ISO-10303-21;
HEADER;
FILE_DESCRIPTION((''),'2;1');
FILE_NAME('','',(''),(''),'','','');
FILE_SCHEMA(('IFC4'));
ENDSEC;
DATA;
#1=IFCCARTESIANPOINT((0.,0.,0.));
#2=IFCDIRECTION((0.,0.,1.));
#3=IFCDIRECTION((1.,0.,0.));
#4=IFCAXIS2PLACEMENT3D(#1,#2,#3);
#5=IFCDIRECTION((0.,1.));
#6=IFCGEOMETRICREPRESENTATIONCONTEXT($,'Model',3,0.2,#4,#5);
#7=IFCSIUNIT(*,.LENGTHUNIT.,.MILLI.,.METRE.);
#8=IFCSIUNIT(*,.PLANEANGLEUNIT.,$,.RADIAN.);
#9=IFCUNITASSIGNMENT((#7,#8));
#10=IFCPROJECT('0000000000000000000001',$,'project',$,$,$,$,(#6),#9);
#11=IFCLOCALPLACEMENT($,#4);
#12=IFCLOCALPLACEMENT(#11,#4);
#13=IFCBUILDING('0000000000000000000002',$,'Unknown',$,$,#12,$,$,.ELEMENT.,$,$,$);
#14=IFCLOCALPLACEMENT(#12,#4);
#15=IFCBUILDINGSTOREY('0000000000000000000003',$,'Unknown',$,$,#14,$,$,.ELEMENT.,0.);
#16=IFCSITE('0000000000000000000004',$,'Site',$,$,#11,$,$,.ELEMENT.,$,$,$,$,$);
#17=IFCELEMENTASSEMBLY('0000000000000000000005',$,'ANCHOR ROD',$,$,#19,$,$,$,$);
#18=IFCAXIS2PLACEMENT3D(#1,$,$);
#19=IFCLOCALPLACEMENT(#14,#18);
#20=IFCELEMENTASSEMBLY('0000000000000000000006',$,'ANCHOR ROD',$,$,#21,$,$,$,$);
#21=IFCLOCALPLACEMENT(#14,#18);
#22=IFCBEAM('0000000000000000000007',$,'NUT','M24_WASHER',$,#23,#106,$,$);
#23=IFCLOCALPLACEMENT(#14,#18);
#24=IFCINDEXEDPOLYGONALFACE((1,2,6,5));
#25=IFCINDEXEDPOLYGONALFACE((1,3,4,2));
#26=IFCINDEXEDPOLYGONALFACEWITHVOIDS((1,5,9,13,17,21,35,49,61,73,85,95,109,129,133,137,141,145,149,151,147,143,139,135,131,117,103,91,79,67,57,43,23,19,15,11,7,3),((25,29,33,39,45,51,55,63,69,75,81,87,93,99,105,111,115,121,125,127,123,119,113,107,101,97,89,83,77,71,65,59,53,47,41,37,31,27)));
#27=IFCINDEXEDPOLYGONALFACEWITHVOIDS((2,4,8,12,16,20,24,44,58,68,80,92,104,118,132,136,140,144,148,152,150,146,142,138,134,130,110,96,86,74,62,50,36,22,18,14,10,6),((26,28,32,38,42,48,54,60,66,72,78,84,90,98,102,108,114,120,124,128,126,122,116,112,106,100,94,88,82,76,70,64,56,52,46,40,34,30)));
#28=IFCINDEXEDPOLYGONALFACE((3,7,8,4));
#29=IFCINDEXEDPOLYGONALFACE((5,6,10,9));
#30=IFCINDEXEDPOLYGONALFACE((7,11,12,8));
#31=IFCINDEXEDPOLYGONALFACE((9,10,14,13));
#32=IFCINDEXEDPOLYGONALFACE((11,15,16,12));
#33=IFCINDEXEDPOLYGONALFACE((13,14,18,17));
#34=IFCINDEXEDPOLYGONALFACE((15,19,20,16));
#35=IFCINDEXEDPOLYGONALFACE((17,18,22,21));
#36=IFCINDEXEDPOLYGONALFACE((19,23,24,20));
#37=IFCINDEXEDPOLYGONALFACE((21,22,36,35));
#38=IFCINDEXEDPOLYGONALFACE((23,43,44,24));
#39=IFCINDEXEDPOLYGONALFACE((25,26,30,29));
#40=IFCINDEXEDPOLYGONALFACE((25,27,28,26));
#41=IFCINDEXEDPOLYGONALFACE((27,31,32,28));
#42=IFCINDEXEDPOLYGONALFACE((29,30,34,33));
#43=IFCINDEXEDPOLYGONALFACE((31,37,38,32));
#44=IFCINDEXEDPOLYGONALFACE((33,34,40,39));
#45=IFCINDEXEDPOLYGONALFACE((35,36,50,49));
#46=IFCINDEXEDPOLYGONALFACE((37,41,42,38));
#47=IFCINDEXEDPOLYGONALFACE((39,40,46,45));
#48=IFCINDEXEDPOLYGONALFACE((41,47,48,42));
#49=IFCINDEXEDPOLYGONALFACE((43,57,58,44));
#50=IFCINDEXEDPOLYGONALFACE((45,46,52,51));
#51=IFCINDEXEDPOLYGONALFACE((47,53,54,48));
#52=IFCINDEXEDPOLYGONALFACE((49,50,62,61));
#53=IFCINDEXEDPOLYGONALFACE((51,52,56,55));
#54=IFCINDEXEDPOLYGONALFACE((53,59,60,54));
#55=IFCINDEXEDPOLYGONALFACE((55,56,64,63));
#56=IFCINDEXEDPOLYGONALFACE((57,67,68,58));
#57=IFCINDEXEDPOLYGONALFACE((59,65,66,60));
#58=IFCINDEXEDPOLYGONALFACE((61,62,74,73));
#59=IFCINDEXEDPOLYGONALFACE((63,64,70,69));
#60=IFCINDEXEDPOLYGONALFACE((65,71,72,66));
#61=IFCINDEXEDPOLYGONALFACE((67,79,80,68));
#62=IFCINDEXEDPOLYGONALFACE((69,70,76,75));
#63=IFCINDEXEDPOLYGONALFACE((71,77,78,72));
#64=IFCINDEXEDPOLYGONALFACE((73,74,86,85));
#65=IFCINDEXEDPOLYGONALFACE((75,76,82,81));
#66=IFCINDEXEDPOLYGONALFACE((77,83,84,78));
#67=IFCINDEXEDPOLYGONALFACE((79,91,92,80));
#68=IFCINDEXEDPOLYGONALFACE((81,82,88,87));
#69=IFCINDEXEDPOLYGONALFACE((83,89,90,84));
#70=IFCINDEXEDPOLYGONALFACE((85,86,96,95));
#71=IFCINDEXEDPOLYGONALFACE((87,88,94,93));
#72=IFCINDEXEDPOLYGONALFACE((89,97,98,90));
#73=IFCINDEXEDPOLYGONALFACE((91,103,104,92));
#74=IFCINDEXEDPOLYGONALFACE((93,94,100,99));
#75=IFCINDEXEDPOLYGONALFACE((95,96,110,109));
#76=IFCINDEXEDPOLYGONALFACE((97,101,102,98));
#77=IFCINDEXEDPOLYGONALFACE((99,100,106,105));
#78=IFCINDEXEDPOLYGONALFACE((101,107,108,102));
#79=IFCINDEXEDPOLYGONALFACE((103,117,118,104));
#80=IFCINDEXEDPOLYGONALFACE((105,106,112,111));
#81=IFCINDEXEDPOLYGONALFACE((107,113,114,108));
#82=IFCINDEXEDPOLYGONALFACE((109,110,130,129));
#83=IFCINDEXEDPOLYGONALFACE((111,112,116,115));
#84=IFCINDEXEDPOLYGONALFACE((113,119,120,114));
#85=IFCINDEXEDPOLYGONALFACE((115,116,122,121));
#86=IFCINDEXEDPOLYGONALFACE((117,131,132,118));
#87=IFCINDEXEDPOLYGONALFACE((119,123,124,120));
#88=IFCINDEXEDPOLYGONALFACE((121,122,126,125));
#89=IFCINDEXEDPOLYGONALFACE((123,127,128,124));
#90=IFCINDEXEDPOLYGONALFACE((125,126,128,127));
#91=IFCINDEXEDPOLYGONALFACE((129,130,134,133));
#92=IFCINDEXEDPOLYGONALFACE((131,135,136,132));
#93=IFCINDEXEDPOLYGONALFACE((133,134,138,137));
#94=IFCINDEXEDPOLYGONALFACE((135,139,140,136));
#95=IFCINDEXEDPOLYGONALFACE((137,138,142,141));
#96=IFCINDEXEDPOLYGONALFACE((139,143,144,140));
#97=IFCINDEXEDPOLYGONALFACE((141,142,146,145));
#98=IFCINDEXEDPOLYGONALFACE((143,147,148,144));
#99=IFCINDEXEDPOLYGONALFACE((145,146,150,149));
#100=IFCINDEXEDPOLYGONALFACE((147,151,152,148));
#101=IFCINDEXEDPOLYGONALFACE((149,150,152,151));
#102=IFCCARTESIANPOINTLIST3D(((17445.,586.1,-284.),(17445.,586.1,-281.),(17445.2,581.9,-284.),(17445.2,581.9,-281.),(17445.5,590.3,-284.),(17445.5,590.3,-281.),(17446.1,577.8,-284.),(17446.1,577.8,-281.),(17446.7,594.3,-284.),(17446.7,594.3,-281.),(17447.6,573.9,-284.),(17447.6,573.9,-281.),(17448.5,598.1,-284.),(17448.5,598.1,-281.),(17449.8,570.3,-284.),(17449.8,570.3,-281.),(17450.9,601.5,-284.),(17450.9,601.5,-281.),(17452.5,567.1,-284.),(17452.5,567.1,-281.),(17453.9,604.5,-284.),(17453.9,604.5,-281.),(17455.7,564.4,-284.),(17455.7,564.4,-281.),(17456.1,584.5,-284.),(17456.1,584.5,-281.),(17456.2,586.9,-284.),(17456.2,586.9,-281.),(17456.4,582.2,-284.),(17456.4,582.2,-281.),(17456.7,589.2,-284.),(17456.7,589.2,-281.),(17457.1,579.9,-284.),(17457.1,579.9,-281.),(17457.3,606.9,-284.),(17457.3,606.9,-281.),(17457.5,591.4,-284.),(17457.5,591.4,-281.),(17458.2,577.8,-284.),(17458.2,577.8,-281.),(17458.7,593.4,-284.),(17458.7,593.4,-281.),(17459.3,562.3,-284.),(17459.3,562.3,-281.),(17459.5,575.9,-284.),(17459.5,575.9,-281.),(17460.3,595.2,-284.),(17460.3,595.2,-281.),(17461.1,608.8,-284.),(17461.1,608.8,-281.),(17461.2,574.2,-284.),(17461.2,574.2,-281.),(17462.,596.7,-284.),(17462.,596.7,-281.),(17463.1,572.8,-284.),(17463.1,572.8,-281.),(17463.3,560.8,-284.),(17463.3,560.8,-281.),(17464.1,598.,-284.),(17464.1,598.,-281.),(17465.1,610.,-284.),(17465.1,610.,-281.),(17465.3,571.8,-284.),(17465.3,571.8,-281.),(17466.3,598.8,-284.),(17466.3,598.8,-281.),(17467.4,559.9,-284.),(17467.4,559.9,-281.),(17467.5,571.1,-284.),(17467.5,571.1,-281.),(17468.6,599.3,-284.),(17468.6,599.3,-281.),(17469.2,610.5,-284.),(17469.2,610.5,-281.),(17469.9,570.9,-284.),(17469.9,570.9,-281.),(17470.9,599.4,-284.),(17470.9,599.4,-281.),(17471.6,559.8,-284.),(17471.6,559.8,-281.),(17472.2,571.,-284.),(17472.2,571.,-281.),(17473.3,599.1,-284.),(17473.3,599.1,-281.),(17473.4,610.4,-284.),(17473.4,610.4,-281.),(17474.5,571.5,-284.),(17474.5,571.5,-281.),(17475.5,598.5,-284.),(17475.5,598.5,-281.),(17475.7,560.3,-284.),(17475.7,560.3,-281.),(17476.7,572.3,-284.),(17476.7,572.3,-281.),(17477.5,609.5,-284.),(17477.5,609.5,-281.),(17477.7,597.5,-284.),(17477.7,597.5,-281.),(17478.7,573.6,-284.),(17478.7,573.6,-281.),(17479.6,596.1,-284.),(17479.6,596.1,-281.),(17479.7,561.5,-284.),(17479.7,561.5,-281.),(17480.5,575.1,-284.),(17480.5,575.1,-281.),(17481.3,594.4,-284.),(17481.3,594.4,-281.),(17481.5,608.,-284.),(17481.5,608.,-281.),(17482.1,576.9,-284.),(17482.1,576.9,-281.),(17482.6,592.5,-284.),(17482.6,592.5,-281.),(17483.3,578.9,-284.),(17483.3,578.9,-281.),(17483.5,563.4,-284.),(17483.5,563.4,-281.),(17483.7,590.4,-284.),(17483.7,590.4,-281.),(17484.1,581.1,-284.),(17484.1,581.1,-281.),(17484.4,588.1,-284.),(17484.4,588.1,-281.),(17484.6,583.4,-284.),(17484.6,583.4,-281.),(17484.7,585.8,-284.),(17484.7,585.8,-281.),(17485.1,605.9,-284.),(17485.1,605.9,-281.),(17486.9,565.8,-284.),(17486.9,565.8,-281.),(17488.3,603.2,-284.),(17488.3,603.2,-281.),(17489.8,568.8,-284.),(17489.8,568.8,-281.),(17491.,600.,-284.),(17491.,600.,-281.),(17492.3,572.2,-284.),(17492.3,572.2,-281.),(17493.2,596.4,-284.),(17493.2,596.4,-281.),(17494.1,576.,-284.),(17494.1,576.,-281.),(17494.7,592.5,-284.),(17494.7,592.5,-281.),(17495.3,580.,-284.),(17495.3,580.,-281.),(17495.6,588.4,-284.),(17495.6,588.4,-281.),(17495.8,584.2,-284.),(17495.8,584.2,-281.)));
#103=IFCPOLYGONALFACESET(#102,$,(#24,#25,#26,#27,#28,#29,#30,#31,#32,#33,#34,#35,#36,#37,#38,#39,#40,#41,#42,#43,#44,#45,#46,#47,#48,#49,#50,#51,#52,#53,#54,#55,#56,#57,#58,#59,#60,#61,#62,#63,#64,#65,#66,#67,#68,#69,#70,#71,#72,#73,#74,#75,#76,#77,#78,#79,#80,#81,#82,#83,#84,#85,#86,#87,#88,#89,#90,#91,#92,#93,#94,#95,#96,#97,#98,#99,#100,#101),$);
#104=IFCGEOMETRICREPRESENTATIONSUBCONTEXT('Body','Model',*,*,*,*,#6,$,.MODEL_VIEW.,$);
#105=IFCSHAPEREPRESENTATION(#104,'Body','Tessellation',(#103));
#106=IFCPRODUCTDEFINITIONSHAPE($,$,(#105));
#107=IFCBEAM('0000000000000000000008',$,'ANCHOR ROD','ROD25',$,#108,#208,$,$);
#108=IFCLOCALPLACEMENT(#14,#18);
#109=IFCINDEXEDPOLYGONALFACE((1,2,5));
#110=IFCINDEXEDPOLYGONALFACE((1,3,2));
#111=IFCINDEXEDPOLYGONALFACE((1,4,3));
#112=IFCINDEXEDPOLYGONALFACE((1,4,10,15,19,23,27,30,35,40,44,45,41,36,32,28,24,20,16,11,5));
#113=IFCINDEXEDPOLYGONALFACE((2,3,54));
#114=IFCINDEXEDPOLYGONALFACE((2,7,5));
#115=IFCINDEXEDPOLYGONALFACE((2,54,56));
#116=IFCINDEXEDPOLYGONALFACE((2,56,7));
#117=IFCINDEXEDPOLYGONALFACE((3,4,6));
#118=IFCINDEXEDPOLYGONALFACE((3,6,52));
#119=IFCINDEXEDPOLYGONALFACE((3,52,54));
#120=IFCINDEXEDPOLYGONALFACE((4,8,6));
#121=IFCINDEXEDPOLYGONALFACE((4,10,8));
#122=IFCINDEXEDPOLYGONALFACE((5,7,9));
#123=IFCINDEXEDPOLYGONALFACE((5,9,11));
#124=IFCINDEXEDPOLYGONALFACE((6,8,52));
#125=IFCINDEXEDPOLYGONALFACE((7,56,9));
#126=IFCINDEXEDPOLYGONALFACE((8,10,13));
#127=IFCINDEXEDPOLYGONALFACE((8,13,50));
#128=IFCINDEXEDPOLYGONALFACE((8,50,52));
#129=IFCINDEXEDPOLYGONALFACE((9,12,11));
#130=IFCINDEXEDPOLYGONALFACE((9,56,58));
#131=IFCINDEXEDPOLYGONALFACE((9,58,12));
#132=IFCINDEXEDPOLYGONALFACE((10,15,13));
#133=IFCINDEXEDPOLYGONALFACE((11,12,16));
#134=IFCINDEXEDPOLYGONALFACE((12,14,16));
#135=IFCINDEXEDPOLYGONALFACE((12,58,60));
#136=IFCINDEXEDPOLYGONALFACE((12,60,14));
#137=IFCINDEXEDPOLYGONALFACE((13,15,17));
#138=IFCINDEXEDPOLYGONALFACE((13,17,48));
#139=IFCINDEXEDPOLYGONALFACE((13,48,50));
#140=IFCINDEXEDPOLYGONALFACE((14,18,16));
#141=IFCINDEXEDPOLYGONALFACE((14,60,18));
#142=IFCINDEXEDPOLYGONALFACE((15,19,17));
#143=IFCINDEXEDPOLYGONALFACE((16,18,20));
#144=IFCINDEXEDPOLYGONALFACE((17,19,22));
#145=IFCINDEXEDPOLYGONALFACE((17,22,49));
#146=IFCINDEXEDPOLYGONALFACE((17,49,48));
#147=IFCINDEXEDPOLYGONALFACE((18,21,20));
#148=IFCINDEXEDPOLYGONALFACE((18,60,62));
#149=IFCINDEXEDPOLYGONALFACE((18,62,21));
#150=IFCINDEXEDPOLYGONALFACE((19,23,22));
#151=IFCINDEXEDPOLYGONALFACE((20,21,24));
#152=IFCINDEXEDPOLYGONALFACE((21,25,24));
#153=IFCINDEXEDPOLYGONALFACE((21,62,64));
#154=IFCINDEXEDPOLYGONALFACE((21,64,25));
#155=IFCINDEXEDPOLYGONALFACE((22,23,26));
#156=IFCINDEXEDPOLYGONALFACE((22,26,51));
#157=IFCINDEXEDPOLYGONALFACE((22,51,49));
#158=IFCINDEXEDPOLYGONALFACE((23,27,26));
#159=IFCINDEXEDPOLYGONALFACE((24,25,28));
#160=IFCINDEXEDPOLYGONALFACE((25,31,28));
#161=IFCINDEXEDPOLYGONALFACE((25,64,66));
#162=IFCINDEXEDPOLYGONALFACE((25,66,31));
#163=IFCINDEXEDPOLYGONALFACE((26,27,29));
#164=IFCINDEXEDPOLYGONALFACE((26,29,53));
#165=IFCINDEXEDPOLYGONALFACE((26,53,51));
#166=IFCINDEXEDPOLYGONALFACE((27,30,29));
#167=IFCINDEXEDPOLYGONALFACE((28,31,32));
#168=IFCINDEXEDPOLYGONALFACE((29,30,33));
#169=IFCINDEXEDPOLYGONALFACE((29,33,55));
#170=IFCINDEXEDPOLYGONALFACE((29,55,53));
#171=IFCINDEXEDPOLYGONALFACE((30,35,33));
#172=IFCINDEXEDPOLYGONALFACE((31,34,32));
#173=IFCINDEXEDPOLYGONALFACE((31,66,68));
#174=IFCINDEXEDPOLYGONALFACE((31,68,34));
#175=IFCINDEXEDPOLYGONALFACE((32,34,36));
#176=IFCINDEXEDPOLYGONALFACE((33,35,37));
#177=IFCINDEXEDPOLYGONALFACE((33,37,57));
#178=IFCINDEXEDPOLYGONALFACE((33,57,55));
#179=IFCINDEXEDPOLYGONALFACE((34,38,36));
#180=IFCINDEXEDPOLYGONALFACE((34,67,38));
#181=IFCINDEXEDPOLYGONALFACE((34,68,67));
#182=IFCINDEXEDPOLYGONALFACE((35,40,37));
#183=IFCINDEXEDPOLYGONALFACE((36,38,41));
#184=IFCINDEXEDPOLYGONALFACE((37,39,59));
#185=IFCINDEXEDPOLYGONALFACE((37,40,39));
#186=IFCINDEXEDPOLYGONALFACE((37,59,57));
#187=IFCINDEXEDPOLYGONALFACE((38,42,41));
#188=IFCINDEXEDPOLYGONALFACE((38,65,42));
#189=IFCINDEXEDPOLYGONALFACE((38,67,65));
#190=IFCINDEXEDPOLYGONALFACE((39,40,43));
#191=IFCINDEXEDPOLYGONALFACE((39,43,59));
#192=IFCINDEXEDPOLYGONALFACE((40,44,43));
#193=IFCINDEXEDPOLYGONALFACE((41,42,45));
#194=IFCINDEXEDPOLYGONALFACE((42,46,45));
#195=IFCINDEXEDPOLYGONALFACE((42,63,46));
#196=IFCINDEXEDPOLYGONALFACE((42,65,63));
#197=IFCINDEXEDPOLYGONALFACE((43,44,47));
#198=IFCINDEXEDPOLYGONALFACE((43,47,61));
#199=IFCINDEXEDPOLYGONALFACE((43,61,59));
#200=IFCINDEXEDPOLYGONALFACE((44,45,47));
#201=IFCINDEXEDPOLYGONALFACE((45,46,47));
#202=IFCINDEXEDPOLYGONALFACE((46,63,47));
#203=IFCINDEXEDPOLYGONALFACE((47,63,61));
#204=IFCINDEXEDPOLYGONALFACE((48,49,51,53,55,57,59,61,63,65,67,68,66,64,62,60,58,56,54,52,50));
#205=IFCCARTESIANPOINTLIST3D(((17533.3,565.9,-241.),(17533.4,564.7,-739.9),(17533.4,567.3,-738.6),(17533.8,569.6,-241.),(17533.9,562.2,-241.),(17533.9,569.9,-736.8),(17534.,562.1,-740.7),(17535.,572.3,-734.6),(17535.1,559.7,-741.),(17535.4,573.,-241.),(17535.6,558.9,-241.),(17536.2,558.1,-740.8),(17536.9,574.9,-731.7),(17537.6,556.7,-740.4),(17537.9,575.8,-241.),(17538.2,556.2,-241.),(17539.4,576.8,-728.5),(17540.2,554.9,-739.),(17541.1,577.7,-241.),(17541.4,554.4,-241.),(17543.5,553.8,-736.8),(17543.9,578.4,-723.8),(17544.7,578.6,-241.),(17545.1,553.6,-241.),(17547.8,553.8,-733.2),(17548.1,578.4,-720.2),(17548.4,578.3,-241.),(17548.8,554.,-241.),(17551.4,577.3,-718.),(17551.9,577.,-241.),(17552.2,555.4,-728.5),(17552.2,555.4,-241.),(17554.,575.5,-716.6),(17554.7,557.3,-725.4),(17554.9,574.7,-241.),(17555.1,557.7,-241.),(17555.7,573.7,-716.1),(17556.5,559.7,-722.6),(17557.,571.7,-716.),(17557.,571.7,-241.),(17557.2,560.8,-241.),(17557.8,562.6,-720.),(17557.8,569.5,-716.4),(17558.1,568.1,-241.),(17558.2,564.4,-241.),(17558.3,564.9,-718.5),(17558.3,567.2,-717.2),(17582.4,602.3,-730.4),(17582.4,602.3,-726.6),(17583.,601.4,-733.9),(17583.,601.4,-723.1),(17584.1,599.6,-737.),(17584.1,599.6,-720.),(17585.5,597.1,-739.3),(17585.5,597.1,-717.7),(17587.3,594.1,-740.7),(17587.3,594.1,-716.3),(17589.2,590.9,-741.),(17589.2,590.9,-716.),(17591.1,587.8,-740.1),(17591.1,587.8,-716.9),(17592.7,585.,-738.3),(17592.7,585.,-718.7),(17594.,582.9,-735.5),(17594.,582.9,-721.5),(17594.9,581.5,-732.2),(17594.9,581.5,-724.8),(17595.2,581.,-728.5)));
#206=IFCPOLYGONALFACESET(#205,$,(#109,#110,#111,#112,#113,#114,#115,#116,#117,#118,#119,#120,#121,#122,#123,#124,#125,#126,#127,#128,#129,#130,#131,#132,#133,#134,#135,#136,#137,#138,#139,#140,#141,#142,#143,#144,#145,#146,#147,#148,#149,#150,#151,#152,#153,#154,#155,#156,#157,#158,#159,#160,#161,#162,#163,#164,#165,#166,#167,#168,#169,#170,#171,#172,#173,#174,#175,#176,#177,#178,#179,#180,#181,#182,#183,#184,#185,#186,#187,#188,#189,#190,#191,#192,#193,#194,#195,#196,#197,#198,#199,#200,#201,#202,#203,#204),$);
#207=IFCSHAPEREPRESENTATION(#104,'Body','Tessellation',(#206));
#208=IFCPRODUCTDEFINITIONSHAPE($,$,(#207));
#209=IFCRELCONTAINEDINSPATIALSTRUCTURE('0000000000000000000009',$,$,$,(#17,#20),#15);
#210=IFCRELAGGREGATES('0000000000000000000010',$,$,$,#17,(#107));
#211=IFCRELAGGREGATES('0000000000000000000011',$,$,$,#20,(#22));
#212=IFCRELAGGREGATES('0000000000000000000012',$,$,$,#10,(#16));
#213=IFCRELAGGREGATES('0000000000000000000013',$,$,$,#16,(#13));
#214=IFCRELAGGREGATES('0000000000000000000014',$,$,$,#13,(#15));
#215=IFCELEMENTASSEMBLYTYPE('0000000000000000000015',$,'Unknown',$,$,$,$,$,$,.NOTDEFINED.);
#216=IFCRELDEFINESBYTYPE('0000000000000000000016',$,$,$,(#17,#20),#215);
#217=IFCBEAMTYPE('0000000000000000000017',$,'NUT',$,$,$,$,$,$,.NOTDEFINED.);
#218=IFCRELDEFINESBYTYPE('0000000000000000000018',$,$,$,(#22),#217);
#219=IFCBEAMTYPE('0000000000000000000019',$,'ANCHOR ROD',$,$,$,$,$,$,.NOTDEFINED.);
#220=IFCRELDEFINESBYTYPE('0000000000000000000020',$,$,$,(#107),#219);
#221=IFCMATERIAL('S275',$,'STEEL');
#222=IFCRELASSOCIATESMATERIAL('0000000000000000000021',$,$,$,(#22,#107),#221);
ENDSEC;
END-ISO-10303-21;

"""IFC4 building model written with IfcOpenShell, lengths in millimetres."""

from ifc_helpers import new_model, entity, si_unit, direction, frame, origin_with_axes, place, context, subcontext, project, spatial, polyline, outline, extrude, material, material_profile, profile_set, profile_usage, type_object, element, aggregate, save


model = new_model("IFC4")

# Units and contexts
model_context = context("Model", 3, precision=0.2, world=origin_with_axes(), true_north=direction((0.0, 1.0)))
body_context = subcontext(model_context, "Body", "Model", "MODEL_VIEW")
ifc_project = project(units=[si_unit("LENGTHUNIT", "METRE", prefix="MILLI"), si_unit("PLANEANGLEUNIT", "RADIAN")], contexts=[model_context])

# Site, building, storey
site_placement = place(None, origin_with_axes())
site = spatial("IfcSite", under=ifc_project, at=site_placement, Name="Site", CompositionType="ELEMENT")
building_placement = place(site_placement, origin_with_axes())
building = spatial("IfcBuilding", under=site, at=building_placement, Name="Unknown", CompositionType="ELEMENT")
storey_placement = place(building_placement, origin_with_axes())
storey = spatial("IfcBuildingStorey", under=building, at=storey_placement, Name="Unknown", CompositionType="ELEMENT", Elevation=0.0)

# Element assemblies, beam
element_assembly_type = type_object("IfcElementAssemblyType", Name="Unknown", PredefinedType="NOTDEFINED")
assembly_1_placement = place(storey_placement, frame((17545.8, 566.1, -241.0), z_axis=(0.512428, -0.85873, 0.0), x_axis=(0.0, 0.0, -1.0)))
assembly_1 = element("IfcElementAssembly", 1, at=assembly_1_placement, inside=storey, type_object=element_assembly_type, Name="ANCHOR ROD")
ifc_material_1 = material(Name="S275", Category="STEEL")
ifc_material_profile_1 = material_profile(ifc_material_1, outline(polyline([(25.4, 0.0), (25.1, 4.2), (24.0, 8.2), (22.3, 12.1), (20.0, 15.6), (17.2, 18.7), (13.9, 21.3), (10.2, 23.3), (6.2, 24.6), (2.1, 25.3), (-2.1, 25.3), (-6.2, 24.6), (-10.2, 23.3), (-13.9, 21.3), (-17.2, 18.7), (-20.0, 15.6), (-22.3, 12.1), (-24.0, 8.2), (-25.1, 4.2), (-25.4, 0.0), (-25.1, -4.2), (-24.0, -8.2), (-22.3, -12.1), (-20.0, -15.6), (-17.2, -18.7), (-13.9, -21.3), (-10.2, -23.3), (-6.2, -24.6), (-2.1, -25.3), (2.1, -25.3), (6.2, -24.6), (10.2, -23.3), (13.9, -21.3), (17.2, -18.7), (20.0, -15.6), (22.3, -12.1), (24.0, -8.2), (25.1, -4.2), (25.4, 0.0)]), holes=[polyline([(0.0, 14.3), (2.4, 14.1), (4.6, 13.5), (6.8, 12.6), (8.8, 11.3), (10.5, 9.7), (12.0, 7.8), (13.1, 5.7), (13.9, 3.5), (14.2, 1.2), (14.2, -1.2), (13.9, -3.5), (13.1, -5.7), (12.0, -7.8), (10.5, -9.7), (8.8, -11.3), (6.8, -12.6), (4.6, -13.5), (2.4, -14.1), (0.0, -14.3), (-2.4, -14.1), (-4.6, -13.5), (-6.8, -12.6), (-8.8, -11.3), (-10.5, -9.7), (-12.0, -7.8), (-13.1, -5.7), (-13.9, -3.5), (-14.2, -1.2), (-14.2, 1.2), (-13.9, 3.5), (-13.1, 5.7), (-12.0, 7.8), (-10.5, 9.7), (-8.8, 11.3), (-6.8, 12.6), (-4.6, 13.5), (-2.4, 14.1), (0.0, 14.3)])]), Name="M24_WASHER")
ifc_profile_set_1 = profile_set([ifc_material_profile_1])
ifc_profile_usage_1 = profile_usage(ifc_profile_set_1, cardinal=5)
beam_type_1 = type_object("IfcBeamType", Name="NUT", PredefinedType="NOTDEFINED")
assembly_2_placement = place(storey_placement, frame((17470.4, 585.1, -241.0), z_axis=(0.512428, -0.85873, 0.0), x_axis=(0.0, 0.0, -1.0)))
assembly_2 = element("IfcElementAssembly", 2, at=assembly_2_placement, inside=storey, type_object=element_assembly_type, Name="ANCHOR ROD")
beam_1_placement = place(assembly_2_placement, frame((40.0, 0.0, 0.0), z_axis=(0.0, -0.003454, -0.999994), x_axis=(1.0, 0.0, 0.0)))
beam_1 = element("IfcBeam", 3, at=beam_1_placement, type_object=beam_type_1, material=ifc_profile_usage_1, Name="NUT", Description="M24_WASHER", context=body_context, shape_type="SolidModel", body=[
    extrude(outline(polyline([(25.4, 0.0), (25.1, 4.2), (24.0, 8.2), (22.3, 12.1), (20.0, 15.6), (17.2, 18.7), (13.9, 21.3), (10.2, 23.3), (6.2, 24.6), (2.1, 25.3), (-2.1, 25.3), (-6.2, 24.6), (-10.2, 23.3), (-13.9, 21.3), (-17.2, 18.7), (-20.0, 15.6), (-22.3, 12.1), (-24.0, 8.2), (-25.1, 4.2), (-25.4, 0.0), (-25.1, -4.2), (-24.0, -8.2), (-22.3, -12.1), (-20.0, -15.6), (-17.2, -18.7), (-13.9, -21.3), (-10.2, -23.3), (-6.2, -24.6), (-2.1, -25.3), (2.1, -25.3), (6.2, -24.6), (10.2, -23.3), (13.9, -21.3), (17.2, -18.7), (20.0, -15.6), (22.3, -12.1), (24.0, -8.2), (25.1, -4.2), (25.4, 0.0)]), holes=[polyline([(0.0, 14.3), (2.4, 14.1), (4.6, 13.5), (6.8, 12.6), (8.8, 11.3), (10.5, 9.7), (12.0, 7.8), (13.1, 5.7), (13.9, 3.5), (14.2, 1.2), (14.2, -1.2), (13.9, -3.5), (13.1, -5.7), (12.0, -7.8), (10.5, -9.7), (8.8, -11.3), (6.8, -12.6), (4.6, -13.5), (2.4, -14.1), (0.0, -14.3), (-2.4, -14.1), (-4.6, -13.5), (-6.8, -12.6), (-8.8, -11.3), (-10.5, -9.7), (-12.0, -7.8), (-13.1, -5.7), (-13.9, -3.5), (-14.2, -1.2), (-14.2, 1.2), (-13.9, 3.5), (-13.1, 5.7), (-12.0, 7.8), (-10.5, 9.7), (-8.8, 11.3), (-6.8, 12.6), (-4.6, 13.5), (-2.4, 14.1), (0.0, 14.3)])]), frame((0.0, 0.0, 0.0), z_axis=(-1.0, 0.0, 0.0), x_axis=(0.0, 0.0, 1.0)), (0.0, 0.0, -1.0), 3.0),
])

# Beam
beam_type_2 = type_object("IfcBeamType", Name="ANCHOR ROD", PredefinedType="NOTDEFINED")
beam_2_placement = place(assembly_1_placement, origin_with_axes())
beam_2 = element("IfcBeam", 4, at=beam_2_placement, type_object=beam_type_2, material=ifc_material_1, Name="ANCHOR ROD", Description="ROD25", context=body_context, shape_type="SolidModel", body=[
    entity("IfcSweptDiskSolid", entity("IfcIndexedPolyCurve", entity("IfcCartesianPointList3D", [[0.0, 0.0, 0.0], [487.5, 0.0, 0.0], [487.5, 50.0, 0.0]]), [entity("IfcLineIndex", [1, 2, 3])]), 12.5),
])
aggregate(assembly_1, [beam_2])
aggregate(assembly_2, [beam_1])

save(model, "model.ifc")
